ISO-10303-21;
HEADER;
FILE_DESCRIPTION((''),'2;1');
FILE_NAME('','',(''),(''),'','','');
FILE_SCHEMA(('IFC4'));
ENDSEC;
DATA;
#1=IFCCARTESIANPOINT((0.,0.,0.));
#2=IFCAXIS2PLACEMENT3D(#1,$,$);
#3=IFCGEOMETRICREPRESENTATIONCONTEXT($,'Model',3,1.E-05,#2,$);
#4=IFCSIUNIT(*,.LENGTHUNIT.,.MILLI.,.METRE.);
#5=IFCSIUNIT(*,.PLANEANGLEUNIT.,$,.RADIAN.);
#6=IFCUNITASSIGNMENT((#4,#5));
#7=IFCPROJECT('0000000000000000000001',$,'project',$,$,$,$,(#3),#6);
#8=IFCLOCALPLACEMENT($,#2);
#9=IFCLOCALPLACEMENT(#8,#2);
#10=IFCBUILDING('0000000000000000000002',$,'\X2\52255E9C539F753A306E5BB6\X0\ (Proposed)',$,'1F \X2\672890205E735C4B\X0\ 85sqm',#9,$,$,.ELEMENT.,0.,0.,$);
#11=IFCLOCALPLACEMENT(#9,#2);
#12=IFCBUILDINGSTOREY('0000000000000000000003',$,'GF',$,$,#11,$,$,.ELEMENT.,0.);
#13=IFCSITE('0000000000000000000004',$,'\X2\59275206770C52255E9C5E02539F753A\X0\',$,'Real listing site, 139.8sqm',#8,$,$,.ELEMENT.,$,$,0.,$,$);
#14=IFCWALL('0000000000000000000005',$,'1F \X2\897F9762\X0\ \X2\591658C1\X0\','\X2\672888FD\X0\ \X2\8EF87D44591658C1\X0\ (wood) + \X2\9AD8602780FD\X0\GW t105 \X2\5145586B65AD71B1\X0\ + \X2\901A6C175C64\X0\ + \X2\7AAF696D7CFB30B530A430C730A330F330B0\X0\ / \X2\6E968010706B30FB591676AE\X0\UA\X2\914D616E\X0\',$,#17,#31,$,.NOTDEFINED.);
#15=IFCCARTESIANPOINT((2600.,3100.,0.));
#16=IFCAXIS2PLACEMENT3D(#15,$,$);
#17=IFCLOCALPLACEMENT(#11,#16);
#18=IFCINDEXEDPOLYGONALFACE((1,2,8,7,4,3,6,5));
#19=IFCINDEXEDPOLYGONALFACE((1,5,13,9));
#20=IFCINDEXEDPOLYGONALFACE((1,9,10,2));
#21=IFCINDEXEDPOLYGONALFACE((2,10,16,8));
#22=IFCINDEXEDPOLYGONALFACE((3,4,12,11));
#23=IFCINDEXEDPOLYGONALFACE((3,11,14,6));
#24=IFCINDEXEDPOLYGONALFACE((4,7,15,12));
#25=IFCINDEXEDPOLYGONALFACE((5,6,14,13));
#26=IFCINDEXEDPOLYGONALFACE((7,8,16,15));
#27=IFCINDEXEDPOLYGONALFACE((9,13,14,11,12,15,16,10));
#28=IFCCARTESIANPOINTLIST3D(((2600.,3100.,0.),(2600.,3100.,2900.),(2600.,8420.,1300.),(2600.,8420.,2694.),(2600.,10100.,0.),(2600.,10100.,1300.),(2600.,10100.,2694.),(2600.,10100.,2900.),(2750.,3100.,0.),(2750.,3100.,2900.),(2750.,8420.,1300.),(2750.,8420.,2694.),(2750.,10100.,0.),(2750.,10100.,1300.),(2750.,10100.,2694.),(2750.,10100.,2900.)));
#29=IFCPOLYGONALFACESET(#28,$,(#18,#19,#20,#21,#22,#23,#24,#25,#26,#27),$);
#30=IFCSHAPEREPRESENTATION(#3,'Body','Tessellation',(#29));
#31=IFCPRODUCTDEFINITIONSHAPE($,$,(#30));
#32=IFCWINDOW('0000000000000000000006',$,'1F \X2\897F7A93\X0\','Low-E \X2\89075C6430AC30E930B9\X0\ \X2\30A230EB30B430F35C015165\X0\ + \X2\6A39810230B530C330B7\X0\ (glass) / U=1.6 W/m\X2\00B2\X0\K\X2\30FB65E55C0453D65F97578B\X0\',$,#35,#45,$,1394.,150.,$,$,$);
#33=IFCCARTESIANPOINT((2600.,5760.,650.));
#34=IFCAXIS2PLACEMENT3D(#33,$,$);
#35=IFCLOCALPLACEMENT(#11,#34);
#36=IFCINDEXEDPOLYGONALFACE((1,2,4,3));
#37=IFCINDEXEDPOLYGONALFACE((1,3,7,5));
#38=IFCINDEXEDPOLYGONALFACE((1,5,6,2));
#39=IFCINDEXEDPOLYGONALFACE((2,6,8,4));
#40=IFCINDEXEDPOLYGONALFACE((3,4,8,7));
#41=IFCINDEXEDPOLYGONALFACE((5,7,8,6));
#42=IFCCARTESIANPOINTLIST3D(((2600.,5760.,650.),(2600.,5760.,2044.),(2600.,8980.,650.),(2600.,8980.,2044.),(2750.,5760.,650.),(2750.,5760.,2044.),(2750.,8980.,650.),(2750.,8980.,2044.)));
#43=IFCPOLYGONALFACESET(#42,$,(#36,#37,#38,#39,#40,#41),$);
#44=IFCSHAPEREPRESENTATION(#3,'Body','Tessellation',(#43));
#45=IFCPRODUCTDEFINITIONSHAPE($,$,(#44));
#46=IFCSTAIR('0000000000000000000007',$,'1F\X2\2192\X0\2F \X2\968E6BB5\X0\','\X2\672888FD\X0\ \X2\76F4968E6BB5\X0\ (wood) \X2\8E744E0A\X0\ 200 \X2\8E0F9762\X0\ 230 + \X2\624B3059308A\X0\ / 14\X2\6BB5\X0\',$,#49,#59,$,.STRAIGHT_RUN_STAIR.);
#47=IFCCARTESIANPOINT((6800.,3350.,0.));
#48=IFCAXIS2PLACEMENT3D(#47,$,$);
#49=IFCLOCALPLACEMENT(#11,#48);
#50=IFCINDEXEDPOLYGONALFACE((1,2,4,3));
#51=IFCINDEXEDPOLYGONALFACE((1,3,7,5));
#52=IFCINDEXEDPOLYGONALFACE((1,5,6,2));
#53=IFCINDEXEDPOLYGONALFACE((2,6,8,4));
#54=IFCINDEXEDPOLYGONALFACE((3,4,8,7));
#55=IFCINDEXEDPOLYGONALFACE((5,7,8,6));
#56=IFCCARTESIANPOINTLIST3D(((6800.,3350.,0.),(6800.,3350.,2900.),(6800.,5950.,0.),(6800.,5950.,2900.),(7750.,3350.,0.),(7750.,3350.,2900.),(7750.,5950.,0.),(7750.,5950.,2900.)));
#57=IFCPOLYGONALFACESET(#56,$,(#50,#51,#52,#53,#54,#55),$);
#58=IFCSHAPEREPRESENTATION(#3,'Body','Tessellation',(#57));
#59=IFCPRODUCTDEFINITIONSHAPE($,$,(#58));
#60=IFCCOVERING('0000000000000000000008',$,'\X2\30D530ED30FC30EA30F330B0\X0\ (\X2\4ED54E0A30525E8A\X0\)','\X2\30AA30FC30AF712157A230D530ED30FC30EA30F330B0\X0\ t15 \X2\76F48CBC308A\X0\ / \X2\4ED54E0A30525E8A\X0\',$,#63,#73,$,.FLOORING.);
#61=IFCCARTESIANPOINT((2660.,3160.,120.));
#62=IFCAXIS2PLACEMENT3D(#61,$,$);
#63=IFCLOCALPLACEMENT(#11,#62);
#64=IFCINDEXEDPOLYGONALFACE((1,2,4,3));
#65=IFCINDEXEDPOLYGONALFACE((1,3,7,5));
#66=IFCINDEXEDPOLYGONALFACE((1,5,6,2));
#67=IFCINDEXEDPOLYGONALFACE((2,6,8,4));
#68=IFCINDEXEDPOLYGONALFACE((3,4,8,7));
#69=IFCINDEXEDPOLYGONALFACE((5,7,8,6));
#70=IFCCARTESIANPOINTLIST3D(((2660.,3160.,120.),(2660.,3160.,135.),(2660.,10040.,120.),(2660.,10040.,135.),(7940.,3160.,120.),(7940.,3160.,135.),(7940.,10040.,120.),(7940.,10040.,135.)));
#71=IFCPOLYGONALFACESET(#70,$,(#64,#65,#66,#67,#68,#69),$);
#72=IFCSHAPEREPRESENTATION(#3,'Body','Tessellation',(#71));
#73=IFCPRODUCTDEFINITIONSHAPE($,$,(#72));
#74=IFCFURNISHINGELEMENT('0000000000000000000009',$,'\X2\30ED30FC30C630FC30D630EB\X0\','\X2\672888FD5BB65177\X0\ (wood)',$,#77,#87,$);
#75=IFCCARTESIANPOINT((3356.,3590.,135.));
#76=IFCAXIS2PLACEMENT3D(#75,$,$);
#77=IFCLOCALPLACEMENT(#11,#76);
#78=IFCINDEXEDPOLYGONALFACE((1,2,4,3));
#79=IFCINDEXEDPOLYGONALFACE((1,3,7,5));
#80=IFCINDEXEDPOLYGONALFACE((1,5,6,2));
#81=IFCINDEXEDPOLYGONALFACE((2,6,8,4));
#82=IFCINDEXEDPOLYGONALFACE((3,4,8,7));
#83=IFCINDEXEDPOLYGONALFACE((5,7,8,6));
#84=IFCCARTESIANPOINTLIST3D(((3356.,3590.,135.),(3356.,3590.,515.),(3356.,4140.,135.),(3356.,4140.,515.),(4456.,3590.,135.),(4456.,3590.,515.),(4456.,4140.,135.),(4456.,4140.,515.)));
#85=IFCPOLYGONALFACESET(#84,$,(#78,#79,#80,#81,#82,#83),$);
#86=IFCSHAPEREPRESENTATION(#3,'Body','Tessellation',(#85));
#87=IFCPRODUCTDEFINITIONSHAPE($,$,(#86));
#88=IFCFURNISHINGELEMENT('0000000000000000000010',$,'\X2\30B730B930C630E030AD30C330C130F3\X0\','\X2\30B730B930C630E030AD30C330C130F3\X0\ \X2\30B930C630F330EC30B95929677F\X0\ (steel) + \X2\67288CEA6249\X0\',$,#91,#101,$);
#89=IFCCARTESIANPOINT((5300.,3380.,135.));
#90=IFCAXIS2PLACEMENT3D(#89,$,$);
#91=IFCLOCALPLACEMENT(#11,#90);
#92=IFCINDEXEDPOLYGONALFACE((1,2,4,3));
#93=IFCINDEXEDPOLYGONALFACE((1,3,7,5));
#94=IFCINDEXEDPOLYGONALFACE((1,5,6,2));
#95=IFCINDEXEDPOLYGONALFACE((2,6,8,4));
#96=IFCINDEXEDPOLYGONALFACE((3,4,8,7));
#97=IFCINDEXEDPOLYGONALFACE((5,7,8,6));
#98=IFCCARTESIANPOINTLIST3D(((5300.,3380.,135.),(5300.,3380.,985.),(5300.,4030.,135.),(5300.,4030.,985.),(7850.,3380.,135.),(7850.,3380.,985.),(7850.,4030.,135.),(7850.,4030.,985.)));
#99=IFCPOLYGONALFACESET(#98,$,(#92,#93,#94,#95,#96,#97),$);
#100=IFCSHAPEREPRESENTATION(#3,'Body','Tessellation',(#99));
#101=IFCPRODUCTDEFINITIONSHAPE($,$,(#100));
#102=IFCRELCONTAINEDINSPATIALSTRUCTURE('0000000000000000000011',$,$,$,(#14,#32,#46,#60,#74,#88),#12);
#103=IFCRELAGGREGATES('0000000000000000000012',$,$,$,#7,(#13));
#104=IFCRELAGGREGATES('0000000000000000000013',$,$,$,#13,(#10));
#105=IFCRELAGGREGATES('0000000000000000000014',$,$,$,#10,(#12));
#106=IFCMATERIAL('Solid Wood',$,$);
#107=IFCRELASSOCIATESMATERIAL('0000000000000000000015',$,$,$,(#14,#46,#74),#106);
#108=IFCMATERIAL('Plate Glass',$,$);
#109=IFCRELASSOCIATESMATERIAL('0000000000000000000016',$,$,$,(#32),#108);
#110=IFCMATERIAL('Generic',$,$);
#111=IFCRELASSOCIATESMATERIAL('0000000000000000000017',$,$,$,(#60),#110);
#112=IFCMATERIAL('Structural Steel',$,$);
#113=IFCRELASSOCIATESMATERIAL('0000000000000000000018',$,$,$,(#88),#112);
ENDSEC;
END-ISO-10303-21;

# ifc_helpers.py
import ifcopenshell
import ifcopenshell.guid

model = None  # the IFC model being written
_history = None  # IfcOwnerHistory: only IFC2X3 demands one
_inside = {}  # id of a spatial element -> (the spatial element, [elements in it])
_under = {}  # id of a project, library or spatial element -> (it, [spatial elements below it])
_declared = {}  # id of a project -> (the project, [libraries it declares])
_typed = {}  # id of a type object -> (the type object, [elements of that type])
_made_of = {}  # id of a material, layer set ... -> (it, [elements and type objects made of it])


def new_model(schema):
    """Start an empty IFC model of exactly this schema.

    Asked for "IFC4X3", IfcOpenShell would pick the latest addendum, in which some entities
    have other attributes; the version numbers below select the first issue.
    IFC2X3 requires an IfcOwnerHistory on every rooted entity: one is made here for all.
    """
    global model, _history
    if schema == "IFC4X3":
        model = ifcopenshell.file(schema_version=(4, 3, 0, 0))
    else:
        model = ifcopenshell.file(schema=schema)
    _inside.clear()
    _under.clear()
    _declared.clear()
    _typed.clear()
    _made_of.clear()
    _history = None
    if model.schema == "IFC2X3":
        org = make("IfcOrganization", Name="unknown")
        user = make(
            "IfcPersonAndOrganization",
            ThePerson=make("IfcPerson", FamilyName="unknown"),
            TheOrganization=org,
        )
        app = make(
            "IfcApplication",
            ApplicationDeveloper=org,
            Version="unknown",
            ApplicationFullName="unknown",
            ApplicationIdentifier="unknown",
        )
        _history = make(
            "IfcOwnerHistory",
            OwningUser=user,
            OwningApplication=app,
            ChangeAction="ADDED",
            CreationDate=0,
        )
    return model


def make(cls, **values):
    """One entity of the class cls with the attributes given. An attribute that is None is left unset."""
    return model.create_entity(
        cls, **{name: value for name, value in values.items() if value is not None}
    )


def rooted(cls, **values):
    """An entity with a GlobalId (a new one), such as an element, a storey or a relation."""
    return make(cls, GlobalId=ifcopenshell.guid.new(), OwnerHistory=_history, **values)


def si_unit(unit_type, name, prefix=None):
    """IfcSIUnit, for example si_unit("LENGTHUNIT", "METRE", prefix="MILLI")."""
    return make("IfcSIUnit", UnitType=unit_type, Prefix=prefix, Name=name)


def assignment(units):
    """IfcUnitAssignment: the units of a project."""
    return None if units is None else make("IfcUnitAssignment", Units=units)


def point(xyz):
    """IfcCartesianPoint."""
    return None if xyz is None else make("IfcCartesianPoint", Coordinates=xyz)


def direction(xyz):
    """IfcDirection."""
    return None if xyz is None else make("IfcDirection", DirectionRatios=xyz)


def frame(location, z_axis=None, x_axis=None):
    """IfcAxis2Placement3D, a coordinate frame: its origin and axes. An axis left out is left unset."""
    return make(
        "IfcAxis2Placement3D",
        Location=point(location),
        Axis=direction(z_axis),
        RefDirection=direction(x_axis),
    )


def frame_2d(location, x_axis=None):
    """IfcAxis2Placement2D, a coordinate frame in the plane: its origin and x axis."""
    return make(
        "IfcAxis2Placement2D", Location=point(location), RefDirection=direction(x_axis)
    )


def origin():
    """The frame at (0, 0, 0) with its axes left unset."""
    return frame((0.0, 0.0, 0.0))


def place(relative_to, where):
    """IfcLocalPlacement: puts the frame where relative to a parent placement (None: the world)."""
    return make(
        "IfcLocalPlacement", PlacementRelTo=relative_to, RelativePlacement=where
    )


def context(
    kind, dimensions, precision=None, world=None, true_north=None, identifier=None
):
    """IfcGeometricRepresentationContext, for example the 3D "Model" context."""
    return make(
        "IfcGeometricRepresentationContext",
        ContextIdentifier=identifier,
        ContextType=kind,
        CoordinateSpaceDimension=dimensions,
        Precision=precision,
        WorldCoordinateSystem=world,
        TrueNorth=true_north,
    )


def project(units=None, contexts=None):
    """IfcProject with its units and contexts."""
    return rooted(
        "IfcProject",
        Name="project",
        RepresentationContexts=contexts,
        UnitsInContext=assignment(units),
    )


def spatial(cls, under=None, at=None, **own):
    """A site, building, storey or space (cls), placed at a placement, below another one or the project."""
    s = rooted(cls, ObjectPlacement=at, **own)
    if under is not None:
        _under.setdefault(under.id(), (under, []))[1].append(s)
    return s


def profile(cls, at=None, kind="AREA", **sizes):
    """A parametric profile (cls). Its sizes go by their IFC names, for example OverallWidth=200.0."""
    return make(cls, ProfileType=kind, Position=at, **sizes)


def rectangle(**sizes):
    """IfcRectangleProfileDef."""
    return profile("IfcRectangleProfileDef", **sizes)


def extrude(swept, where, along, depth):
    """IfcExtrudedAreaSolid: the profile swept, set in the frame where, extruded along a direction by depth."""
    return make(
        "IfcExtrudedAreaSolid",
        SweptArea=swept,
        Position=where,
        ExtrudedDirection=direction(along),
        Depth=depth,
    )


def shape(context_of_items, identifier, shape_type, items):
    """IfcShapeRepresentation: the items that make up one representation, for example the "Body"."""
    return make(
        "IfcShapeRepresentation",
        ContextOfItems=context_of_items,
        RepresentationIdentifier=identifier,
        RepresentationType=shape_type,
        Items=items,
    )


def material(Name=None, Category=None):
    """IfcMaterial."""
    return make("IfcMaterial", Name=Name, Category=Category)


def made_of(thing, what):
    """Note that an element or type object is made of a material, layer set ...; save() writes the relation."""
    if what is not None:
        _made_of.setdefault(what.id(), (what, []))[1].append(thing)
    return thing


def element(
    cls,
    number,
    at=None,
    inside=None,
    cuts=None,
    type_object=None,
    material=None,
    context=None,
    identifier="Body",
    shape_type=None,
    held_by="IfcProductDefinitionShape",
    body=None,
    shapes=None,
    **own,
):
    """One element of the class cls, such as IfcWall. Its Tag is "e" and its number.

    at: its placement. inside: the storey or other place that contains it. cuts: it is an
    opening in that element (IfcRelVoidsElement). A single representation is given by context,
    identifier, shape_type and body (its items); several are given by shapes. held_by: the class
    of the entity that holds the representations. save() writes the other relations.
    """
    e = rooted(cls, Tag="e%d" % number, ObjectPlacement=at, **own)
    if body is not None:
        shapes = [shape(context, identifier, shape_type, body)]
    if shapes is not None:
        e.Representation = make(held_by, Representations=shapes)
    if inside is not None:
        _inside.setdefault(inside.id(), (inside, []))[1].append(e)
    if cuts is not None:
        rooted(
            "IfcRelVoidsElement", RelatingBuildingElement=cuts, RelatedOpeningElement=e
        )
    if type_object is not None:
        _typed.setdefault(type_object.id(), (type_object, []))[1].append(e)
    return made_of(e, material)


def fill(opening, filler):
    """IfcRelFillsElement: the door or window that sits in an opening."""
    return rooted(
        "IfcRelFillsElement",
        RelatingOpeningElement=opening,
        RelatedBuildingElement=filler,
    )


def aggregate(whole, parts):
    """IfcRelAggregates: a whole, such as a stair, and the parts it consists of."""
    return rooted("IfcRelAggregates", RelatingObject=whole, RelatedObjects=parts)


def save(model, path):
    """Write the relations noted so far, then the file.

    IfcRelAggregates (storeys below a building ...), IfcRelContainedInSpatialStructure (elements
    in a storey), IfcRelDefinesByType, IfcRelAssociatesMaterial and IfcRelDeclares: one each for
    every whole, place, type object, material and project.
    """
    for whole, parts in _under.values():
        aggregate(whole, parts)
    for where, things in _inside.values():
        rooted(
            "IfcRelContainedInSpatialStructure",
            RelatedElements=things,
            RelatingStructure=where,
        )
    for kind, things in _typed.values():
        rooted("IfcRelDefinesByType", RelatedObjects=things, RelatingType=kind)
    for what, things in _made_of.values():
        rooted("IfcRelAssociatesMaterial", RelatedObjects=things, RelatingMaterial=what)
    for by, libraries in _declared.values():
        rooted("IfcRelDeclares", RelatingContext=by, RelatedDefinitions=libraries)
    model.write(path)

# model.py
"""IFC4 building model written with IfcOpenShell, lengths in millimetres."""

from ifc_helpers import new_model, si_unit, frame, frame_2d, origin, place, context, project, spatial, rectangle, extrude, material, element, fill, save


model = new_model("IFC4")

# Units and contexts
model_context = context("Model", 3, precision=1e-05, world=origin())
ifc_project = project(units=[si_unit("LENGTHUNIT", "METRE", prefix="MILLI"), si_unit("PLANEANGLEUNIT", "RADIAN")], contexts=[model_context])

# Site, building, storey
site_placement = place(None, origin())
site = spatial("IfcSite", under=ifc_project, at=site_placement, Name="大分県別府市原町", ObjectType="Real listing site, 139.8sqm", CompositionType="ELEMENT", RefElevation=0.0)
building_placement = place(site_placement, origin())
building = spatial("IfcBuilding", under=site, at=building_placement, Name="別府原町の家 (Proposed)", ObjectType="1F 木造平屋 85sqm", CompositionType="ELEMENT", ElevationOfRefHeight=0.0, ElevationOfTerrain=0.0)
storey_placement = place(building_placement, origin())
storey = spatial("IfcBuildingStorey", under=building, at=storey_placement, Name="GF", CompositionType="ELEMENT", Elevation=0.0)

# Shared definitions
ifc_material_1 = material(Name="Solid Wood")
ifc_material_2 = material(Name="Generic")

# Shared definitions
ifc_material_3 = material(Name="Plate Glass")

# Wall, opening, window
wall_1_placement = place(storey_placement, frame((2600.0, 3100.0, 0.0)))
wall_1 = element("IfcWall", 1, at=wall_1_placement, inside=storey, material=ifc_material_1, Name="1F 西面 外壁", Description="木製 軸組外壁 (wood) + 高性能GW t105 充填断熱 + 通気層 + 窯業系サイディング / 準耐火・外皮UA配慮", PredefinedType="NOTDEFINED", context=model_context, shape_type="SweptSolid", body=[
    extrude(rectangle(XDim=150.0, YDim=7000.0, at=frame_2d((75.0, 3500.0))), frame((2600.0, 3100.0, 0.0)), (0.0, 0.0, 1.0), 2900.0),
])
opening_1_placement = place(storey_placement, frame((2600.0, 5760.0, 650.0)))
opening_1 = element("IfcOpeningElement", 2, at=opening_1_placement, cuts=wall_1, PredefinedType="NOTDEFINED", context=model_context, shape_type="SweptSolid", body=[
    extrude(rectangle(XDim=150.0, YDim=3220.0, at=frame_2d((75.0, 1610.0))), frame((2600.0, 5760.0, 650.0)), (0.0, 0.0, 1.0), 1394.0),
])
window_1_placement = place(storey_placement, frame((2600.0, 5760.0, 650.0)))
window_1 = element("IfcWindow", 3, at=window_1_placement, inside=storey, material=ifc_material_3, Name="1F 西窓", Description="Low-E 複層ガラス アルゴン封入 + 樹脂サッシ (glass) / U=1.6 W/m²K・日射取得型", OverallHeight=1394.0, OverallWidth=150.0, context=model_context, shape_type="SweptSolid", body=[
    extrude(rectangle(XDim=150.0, YDim=3220.0, at=frame_2d((75.0, 1610.0))), frame((2600.0, 5760.0, 650.0)), (0.0, 0.0, 1.0), 1394.0),
])
fill(opening_1, window_1)

# Stair
stair_placement = place(storey_placement, frame((6800.0, 3350.0, 0.0)))
element("IfcStair", 4, at=stair_placement, inside=storey, material=ifc_material_1, Name="1F→2F 階段", Description="木製 直階段 (wood) 蹴上 200 踏面 230 + 手すり / 14段", PredefinedType="STRAIGHT_RUN_STAIR", context=model_context, shape_type="SweptSolid", body=[
    extrude(rectangle(XDim=950.0, YDim=2600.0, at=frame_2d((475.0, 1300.0))), frame((6800.0, 3350.0, 0.0)), (0.0, 0.0, 1.0), 2900.0),
])

# Covering
covering_placement = place(storey_placement, frame((2660.0, 3160.0, 120.0)))
element("IfcCovering", 5, at=covering_placement, inside=storey, material=ifc_material_2, Name="フローリング (仕上げ床)", Description="オーク無垢フローリング t15 直貼り / 仕上げ床", PredefinedType="FLOORING", context=model_context, shape_type="SweptSolid", body=[
    extrude(rectangle(XDim=5280.0, YDim=6880.0, at=frame_2d((2640.0, 3440.0))), frame((2660.0, 3160.0, 120.0)), (0.0, 0.0, 1.0), 15.0),
])

# Furnishing elements
furnishing_1_placement = place(storey_placement, frame((3356.0, 3590.0, 135.0)))
element("IfcFurnishingElement", 6, at=furnishing_1_placement, inside=storey, material=ifc_material_1, Name="ローテーブル", Description="木製家具 (wood)", context=model_context, shape_type="SweptSolid", body=[
    extrude(rectangle(XDim=1100.0, YDim=550.0, at=frame_2d((550.0, 275.0))), frame((3356.0, 3590.0, 135.0)), (0.0, 0.0, 1.0), 380.0),
])
ifc_material_4 = material(Name="Structural Steel")
furnishing_2_placement = place(storey_placement, frame((5300.0, 3380.0, 135.0)))
element("IfcFurnishingElement", 7, at=furnishing_2_placement, inside=storey, material=ifc_material_4, Name="システムキッチン", Description="システムキッチン ステンレス天板 (steel) + 木質扉", context=model_context, shape_type="SweptSolid", body=[
    extrude(rectangle(XDim=2550.0, YDim=650.0, at=frame_2d((1275.0, 325.0))), frame((5300.0, 3380.0, 135.0)), (0.0, 0.0, 1.0), 850.0),
])

save(model, "model.ifc")
